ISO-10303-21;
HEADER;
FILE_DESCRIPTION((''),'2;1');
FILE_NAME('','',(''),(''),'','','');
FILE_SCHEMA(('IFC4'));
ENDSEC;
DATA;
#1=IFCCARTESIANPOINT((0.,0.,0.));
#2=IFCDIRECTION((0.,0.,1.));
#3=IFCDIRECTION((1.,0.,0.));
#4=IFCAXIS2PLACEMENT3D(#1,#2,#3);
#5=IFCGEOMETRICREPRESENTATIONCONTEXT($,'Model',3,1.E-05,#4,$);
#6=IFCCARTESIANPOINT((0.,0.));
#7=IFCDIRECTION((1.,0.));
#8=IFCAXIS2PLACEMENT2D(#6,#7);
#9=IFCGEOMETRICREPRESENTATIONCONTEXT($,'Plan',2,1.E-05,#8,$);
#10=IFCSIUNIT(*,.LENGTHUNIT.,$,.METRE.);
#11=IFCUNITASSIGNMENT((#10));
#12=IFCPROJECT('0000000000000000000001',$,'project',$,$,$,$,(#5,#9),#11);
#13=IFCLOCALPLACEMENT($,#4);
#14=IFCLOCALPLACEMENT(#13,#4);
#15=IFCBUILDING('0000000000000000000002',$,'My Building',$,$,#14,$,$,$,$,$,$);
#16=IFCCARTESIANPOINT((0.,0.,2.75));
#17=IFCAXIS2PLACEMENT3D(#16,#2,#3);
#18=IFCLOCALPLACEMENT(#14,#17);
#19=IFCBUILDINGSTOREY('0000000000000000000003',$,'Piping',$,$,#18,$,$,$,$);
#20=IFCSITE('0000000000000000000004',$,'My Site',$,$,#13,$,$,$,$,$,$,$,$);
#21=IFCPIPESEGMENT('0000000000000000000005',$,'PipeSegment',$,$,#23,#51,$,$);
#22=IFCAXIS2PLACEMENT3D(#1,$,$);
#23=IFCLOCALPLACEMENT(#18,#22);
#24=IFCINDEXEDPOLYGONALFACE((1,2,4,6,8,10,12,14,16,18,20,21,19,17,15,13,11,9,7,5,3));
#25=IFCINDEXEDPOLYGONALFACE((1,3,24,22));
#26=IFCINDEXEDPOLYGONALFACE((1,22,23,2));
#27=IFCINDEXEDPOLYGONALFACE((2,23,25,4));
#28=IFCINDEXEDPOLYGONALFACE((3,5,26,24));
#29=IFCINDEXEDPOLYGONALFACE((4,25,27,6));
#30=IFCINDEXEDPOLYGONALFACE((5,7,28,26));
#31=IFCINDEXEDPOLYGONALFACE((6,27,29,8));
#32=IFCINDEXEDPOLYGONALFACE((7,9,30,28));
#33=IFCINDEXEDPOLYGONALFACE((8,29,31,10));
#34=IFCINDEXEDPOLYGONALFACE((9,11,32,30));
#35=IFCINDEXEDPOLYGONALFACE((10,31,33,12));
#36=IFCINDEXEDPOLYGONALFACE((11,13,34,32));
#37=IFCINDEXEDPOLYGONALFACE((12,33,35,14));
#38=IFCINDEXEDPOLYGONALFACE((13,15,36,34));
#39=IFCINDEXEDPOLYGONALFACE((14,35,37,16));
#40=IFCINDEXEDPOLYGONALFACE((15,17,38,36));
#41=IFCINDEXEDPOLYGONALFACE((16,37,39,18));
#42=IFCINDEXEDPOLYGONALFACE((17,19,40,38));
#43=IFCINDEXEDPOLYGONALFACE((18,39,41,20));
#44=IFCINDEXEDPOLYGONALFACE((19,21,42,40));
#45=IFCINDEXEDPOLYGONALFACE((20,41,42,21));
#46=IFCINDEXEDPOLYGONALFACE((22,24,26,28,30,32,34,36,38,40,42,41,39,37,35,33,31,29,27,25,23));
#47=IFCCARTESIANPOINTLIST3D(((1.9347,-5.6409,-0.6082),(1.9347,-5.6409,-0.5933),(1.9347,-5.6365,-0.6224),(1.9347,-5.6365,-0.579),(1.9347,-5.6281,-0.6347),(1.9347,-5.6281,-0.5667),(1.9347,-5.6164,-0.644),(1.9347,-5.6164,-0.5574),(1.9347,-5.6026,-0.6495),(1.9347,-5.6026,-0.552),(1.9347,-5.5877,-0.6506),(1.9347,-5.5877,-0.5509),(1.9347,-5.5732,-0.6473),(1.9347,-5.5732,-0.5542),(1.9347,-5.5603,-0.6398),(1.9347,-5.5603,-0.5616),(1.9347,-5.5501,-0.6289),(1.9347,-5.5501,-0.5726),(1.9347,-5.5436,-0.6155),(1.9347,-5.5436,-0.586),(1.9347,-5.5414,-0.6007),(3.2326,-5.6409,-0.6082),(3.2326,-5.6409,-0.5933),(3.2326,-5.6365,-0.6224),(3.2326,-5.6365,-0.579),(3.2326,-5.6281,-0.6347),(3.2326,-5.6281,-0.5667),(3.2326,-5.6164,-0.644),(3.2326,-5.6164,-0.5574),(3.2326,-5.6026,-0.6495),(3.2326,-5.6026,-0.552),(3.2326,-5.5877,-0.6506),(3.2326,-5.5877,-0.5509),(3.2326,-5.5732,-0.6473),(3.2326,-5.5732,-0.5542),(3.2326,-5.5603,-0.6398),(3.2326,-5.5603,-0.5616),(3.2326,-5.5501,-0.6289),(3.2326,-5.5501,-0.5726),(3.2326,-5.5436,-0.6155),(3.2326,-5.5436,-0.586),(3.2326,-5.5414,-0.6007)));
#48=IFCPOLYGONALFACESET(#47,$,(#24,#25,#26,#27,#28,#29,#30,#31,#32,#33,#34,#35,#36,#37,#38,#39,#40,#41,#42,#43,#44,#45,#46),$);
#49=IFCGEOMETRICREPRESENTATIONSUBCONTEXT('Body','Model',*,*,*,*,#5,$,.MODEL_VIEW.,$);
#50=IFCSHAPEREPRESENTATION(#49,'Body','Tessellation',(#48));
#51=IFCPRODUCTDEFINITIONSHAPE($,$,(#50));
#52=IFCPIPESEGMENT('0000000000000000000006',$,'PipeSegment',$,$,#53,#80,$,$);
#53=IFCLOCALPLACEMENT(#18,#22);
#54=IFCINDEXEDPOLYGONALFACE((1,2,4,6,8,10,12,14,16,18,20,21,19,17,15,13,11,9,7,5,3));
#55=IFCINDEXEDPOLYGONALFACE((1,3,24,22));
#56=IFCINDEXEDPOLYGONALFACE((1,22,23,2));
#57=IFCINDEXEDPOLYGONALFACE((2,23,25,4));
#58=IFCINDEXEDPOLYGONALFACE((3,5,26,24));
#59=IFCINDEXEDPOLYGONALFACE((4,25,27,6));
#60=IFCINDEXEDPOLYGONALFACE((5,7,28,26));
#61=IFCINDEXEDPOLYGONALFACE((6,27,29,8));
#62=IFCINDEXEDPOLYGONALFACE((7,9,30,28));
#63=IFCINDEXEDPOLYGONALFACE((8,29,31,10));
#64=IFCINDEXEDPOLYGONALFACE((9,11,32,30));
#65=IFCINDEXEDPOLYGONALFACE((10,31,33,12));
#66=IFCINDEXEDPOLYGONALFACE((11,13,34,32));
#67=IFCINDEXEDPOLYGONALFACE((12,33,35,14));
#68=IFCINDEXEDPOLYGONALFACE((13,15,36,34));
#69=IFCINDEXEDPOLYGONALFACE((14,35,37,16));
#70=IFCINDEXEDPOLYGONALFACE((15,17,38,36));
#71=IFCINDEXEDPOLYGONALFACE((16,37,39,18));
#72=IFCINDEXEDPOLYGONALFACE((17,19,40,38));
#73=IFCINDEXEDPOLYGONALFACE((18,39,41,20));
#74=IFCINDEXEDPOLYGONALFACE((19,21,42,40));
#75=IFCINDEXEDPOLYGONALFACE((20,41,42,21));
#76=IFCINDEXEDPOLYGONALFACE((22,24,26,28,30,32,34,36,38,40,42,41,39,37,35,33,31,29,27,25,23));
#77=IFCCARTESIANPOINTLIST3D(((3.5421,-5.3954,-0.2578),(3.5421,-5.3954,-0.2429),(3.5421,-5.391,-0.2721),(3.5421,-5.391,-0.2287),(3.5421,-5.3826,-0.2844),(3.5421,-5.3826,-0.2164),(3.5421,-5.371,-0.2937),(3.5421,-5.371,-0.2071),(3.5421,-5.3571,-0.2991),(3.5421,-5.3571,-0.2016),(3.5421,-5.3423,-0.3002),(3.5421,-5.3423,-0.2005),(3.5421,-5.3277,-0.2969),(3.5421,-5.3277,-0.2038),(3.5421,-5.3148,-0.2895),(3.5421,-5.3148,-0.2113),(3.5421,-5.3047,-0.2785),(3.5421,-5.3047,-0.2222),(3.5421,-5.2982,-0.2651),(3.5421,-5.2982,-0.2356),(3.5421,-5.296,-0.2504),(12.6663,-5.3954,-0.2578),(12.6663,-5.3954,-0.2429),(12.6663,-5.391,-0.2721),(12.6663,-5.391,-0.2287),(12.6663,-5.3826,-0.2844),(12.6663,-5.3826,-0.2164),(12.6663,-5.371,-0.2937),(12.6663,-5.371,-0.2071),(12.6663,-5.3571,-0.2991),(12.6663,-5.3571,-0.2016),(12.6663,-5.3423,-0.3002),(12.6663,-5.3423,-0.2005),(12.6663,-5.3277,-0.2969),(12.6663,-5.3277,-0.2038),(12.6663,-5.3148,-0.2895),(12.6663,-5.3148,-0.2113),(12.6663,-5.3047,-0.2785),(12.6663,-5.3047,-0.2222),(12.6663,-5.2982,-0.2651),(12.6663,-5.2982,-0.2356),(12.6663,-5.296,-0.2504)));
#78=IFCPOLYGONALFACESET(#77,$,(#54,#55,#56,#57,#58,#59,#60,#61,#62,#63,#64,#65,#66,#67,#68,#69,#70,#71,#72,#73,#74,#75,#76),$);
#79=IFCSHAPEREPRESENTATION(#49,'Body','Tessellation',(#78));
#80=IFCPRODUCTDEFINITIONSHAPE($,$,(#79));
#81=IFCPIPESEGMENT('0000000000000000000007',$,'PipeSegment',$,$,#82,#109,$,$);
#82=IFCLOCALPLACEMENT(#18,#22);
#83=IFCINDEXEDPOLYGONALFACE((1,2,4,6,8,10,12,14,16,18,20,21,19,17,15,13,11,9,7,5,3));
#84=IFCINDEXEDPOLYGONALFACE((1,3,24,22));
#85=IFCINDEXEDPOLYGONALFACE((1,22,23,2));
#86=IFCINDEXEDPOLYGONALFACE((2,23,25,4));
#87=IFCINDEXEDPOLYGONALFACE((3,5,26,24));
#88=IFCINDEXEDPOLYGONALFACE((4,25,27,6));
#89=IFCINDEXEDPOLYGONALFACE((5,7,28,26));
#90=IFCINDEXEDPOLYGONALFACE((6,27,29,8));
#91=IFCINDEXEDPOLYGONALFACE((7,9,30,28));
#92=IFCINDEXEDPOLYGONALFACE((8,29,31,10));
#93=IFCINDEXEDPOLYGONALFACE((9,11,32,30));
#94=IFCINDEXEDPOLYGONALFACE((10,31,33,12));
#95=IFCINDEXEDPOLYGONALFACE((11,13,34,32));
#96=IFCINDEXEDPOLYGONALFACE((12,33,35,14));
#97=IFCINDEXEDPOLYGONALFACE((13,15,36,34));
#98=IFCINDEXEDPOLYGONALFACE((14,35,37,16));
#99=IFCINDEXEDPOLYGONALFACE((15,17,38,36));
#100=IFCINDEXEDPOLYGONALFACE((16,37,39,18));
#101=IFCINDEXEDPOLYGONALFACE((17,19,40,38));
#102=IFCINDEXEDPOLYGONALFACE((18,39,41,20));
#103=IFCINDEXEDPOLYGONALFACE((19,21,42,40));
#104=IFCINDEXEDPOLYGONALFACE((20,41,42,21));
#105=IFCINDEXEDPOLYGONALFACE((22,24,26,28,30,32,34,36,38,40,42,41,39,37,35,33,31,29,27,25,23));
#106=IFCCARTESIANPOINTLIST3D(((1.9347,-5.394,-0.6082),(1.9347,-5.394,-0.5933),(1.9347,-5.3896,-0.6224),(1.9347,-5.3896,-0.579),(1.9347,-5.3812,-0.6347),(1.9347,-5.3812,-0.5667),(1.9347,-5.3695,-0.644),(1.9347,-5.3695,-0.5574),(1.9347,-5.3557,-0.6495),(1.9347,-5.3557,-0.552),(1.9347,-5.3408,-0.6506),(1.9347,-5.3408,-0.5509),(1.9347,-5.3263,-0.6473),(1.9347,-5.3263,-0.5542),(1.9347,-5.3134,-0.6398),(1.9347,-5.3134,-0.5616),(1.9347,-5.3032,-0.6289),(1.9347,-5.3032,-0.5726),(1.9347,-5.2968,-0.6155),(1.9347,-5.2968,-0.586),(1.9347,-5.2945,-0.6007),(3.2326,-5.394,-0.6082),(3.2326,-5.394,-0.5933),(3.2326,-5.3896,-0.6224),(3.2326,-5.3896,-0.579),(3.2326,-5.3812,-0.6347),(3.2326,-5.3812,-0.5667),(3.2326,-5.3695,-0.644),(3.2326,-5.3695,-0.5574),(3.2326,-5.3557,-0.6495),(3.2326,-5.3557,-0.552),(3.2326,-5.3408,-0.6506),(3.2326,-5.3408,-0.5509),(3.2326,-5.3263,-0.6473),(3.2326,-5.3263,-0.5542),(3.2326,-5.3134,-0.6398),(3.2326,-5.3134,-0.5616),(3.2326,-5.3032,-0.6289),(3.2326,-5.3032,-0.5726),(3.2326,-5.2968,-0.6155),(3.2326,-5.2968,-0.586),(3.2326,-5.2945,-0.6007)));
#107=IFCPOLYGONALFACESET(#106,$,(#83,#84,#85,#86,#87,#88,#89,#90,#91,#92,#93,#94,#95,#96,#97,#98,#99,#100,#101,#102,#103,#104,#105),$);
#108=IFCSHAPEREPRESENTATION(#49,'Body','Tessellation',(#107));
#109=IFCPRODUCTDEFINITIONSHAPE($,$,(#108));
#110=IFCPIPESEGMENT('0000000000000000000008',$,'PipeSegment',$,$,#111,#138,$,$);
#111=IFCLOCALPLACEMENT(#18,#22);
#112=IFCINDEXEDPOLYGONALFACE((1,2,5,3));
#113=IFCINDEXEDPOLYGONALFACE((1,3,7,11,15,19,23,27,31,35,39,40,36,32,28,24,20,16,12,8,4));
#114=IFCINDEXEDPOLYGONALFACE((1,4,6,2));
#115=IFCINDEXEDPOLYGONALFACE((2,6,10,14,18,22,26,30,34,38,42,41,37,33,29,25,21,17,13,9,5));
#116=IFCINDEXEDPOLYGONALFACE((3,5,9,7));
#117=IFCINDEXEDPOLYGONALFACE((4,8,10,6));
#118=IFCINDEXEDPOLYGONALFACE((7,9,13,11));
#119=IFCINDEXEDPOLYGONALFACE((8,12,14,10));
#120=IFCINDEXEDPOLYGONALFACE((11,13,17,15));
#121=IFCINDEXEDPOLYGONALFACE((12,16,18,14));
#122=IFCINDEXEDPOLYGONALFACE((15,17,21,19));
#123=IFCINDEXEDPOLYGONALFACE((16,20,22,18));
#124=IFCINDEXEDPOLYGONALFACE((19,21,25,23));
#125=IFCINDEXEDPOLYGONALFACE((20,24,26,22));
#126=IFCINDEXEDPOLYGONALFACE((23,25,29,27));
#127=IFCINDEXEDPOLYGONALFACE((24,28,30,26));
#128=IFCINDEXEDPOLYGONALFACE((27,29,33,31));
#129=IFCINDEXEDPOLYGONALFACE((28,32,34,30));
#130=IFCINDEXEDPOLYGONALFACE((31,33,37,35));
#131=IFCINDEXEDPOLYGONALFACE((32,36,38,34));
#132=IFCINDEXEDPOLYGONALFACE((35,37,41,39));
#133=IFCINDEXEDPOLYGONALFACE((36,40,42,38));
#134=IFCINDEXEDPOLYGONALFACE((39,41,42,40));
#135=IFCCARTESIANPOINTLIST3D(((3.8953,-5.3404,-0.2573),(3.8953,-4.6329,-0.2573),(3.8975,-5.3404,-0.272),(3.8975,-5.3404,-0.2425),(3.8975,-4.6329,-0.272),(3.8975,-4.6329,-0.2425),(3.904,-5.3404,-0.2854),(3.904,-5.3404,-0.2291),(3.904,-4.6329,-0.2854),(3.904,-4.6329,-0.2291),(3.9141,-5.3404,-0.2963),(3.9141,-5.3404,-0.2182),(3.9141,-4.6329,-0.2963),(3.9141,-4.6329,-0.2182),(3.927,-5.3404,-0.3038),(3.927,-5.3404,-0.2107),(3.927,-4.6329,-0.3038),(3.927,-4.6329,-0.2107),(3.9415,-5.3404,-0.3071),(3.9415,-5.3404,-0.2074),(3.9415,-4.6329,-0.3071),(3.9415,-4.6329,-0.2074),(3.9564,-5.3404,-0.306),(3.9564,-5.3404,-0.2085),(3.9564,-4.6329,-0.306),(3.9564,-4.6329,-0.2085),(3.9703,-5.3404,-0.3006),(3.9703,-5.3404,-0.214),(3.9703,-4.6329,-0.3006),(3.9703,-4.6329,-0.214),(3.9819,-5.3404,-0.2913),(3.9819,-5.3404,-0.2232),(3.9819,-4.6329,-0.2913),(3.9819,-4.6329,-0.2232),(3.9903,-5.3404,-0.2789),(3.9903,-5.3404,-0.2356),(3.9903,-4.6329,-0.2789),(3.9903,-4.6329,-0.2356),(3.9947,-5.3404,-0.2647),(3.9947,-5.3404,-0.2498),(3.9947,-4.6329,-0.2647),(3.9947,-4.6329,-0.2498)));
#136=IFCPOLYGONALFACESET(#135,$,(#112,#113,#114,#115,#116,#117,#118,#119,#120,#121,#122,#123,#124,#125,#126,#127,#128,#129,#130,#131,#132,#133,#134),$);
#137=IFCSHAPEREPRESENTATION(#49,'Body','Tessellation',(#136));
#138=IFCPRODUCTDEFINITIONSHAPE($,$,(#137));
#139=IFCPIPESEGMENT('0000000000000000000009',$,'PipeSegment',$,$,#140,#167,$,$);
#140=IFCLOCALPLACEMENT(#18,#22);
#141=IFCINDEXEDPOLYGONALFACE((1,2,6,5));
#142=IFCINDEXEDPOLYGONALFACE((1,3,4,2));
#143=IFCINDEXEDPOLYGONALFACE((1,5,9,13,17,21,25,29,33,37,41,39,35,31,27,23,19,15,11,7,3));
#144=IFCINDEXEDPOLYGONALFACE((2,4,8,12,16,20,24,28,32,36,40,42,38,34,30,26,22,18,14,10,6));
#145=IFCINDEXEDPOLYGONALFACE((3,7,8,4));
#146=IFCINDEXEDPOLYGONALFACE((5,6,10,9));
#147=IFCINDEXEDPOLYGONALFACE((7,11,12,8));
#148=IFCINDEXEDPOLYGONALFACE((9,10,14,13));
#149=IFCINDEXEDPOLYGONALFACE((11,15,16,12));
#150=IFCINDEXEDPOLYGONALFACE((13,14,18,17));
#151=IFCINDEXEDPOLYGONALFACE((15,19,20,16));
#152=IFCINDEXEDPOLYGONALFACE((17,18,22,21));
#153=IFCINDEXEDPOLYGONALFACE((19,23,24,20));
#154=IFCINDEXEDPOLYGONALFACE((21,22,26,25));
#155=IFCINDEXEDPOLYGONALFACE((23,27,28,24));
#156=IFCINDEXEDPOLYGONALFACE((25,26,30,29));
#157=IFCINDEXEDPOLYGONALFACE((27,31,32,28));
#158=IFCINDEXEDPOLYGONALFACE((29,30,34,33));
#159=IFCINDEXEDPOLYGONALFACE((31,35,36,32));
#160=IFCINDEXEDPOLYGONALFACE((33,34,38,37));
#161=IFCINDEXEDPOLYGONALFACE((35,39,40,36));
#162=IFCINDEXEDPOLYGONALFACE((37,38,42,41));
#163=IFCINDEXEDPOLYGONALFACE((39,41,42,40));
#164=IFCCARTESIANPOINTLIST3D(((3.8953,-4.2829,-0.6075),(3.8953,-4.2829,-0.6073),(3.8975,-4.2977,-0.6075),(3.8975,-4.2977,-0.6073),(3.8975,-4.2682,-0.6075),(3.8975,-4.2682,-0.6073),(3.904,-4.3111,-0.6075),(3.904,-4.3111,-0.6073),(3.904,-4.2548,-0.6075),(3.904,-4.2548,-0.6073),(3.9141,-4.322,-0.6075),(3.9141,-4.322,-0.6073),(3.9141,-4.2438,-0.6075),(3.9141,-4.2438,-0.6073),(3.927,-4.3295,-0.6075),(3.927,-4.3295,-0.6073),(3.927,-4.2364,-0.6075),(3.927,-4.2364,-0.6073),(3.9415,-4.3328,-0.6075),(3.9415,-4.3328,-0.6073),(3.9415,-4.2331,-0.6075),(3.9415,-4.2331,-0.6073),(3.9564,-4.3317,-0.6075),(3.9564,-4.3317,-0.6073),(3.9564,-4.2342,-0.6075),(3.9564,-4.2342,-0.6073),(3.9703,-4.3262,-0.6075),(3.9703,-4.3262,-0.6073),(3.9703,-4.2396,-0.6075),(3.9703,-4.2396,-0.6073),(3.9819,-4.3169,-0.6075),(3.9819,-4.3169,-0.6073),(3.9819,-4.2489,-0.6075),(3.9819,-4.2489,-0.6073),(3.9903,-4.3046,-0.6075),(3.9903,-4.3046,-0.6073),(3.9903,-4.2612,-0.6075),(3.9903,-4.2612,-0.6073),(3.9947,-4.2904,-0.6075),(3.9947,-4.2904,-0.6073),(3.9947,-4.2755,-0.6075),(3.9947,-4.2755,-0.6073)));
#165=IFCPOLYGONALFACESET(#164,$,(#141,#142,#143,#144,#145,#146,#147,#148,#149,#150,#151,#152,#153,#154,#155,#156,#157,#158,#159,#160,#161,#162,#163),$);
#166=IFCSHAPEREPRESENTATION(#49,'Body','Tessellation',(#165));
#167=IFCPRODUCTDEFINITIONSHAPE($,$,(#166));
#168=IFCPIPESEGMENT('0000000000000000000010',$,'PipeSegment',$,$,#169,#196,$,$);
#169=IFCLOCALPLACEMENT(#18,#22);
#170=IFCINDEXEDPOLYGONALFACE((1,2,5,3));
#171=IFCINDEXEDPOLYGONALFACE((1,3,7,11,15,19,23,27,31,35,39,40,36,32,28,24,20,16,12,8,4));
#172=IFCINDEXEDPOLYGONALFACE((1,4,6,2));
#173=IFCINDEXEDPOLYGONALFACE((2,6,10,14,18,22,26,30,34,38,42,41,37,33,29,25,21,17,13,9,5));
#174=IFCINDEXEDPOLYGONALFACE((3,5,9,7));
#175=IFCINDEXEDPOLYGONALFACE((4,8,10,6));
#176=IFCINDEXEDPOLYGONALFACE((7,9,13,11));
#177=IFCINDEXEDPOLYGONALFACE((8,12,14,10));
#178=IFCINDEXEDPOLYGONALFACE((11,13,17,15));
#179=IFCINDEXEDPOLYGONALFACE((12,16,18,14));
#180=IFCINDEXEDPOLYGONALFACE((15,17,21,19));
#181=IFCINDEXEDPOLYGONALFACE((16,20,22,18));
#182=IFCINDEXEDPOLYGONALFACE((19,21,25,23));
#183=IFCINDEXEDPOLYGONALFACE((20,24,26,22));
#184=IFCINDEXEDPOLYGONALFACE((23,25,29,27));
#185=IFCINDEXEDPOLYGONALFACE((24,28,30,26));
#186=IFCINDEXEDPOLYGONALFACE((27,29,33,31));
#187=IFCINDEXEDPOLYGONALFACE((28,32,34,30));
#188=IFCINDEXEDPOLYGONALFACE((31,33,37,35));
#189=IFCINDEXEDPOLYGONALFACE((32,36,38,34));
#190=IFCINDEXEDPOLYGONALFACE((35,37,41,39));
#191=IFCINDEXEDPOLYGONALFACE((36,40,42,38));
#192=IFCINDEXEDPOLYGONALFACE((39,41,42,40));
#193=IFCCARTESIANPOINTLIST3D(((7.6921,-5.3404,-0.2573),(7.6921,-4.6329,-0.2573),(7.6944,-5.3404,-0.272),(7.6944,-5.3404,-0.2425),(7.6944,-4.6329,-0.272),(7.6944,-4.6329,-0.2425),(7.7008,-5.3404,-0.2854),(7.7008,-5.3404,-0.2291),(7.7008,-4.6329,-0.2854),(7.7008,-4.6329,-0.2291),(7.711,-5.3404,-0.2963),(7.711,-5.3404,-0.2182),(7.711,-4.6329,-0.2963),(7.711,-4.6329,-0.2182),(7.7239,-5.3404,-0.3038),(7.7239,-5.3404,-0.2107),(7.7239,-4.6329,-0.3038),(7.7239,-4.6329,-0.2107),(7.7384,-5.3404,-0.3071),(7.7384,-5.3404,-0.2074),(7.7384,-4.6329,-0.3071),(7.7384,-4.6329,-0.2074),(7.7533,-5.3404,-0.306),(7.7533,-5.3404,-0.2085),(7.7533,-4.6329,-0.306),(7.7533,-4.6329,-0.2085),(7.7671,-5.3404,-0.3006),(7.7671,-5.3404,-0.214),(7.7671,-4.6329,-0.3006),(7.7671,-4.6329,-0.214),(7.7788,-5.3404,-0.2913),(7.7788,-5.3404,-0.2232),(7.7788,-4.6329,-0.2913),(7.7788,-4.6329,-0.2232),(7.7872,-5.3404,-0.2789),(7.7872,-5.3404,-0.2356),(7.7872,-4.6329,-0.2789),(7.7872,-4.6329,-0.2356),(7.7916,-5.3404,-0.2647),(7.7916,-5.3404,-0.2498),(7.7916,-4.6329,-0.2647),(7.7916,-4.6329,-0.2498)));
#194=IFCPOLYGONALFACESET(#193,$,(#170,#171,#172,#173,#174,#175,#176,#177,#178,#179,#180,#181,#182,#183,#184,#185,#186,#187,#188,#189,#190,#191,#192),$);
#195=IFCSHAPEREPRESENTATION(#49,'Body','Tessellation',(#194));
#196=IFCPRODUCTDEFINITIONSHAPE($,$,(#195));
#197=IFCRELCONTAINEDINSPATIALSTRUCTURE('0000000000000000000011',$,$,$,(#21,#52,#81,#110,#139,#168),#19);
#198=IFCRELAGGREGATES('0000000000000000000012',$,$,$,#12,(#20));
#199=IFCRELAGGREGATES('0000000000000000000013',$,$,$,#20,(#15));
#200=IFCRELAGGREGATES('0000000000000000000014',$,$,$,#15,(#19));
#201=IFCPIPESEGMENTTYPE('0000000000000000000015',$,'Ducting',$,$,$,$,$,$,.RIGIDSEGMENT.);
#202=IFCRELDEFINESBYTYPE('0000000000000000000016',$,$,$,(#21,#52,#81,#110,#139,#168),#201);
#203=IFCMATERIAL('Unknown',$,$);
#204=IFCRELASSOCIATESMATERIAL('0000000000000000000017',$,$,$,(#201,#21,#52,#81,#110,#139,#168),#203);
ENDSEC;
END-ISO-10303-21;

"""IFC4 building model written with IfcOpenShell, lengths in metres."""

from ifc_helpers import new_model, si_unit, frame, origin_with_axes, origin_2d_with_axis, place, context, subcontext, project, spatial, circle, extrude, material, material_profile, profile_set, profile_usage, type_object, element, save


model = new_model("IFC4")

# Units and contexts
model_context = context("Model", 3, precision=1e-05, world=origin_with_axes())
plan_context = context("Plan", 2, precision=1e-05, world=origin_2d_with_axis())
body_context = subcontext(model_context, "Body", "Model", "MODEL_VIEW")
ifc_project = project(units=[si_unit("LENGTHUNIT", "METRE")], contexts=[model_context, plan_context])

# Site, building, storey
site_placement = place(None, origin_with_axes())
site = spatial("IfcSite", under=ifc_project, at=site_placement, Name="My Site")
building_placement = place(site_placement, origin_with_axes())
building = spatial("IfcBuilding", under=site, at=building_placement, Name="My Building")
storey_placement = place(building_placement, frame((0.0, 0.0, 2.75), z_axis=(0.0, 0.0, 1.0), x_axis=(1.0, 0.0, 0.0)))
storey = spatial("IfcBuildingStorey", under=building, at=storey_placement, Name="Piping")

# Pipe segments
ifc_material = material(Name="Unknown")
ifc_material_profile = material_profile(ifc_material, circle(Radius=0.05))
ifc_profile_set = profile_set([ifc_material_profile])
pipe_segment_type = type_object("IfcPipeSegmentType", Name="Ducting", PredefinedType="RIGIDSEGMENT", material=ifc_profile_set)
ifc_profile_usage_1 = profile_usage(ifc_profile_set, cardinal=4)
pipe_segment_1_placement = place(storey_placement, frame((1.9347, -5.5414, -0.6007), z_axis=(1.0, 0.0, 0.0), x_axis=(0.0, 1.0, 0.0)))
element("IfcPipeSegment", 1, at=pipe_segment_1_placement, inside=storey, type_object=pipe_segment_type, material=ifc_profile_usage_1, Name="PipeSegment", context=body_context, shape_type="SweptSolid", body=[
    extrude(circle(Radius=0.05), frame((-0.05, 0.0, 0.0), z_axis=(0.0, 0.0, 1.0), x_axis=(1.0, 0.0, 0.0)), (0.0, 0.0, 1.0), 1.298),
])
ifc_profile_usage_2 = profile_usage(ifc_profile_set, cardinal=4)
pipe_segment_2_placement = place(storey_placement, frame((3.5421, -5.296, -0.2504), z_axis=(1.0, -0.000001, 0.000001), x_axis=(0.000001, 1.0, 0.0)))
element("IfcPipeSegment", 2, at=pipe_segment_2_placement, inside=storey, type_object=pipe_segment_type, material=ifc_profile_usage_2, Name="PipeSegment", context=body_context, shape_type="SweptSolid", body=[
    extrude(circle(Radius=0.05), frame((-0.05, 0.0, 0.0), z_axis=(0.0, 0.0, 1.0), x_axis=(1.0, 0.0, 0.0)), (0.0, 0.0, 1.0), 9.1242),
])
ifc_profile_usage_3 = profile_usage(ifc_profile_set, cardinal=4)
pipe_segment_3_placement = place(storey_placement, frame((1.9347, -5.2945, -0.6007), z_axis=(1.0, 0.0, 0.0), x_axis=(0.0, 1.0, 0.0)))
element("IfcPipeSegment", 3, at=pipe_segment_3_placement, inside=storey, type_object=pipe_segment_type, material=ifc_profile_usage_3, Name="PipeSegment", context=body_context, shape_type="SweptSolid", body=[
    extrude(circle(Radius=0.05), frame((-0.05, 0.0, 0.0), z_axis=(0.0, 0.0, 1.0), x_axis=(1.0, 0.0, 0.0)), (0.0, 0.0, 1.0), 1.298),
])
ifc_profile_usage_4 = profile_usage(ifc_profile_set, cardinal=4)
pipe_segment_4_placement = place(storey_placement, frame((3.8953, -5.3404, -0.2573), z_axis=(0.0, 1.0, 0.0), x_axis=(-1.0, 0.0, 0.0)))
element("IfcPipeSegment", 4, at=pipe_segment_4_placement, inside=storey, type_object=pipe_segment_type, material=ifc_profile_usage_4, Name="PipeSegment", context=body_context, shape_type="SweptSolid", body=[
    extrude(circle(Radius=0.05), frame((-0.05, 0.0, 0.0), z_axis=(0.0, 0.0, 1.0), x_axis=(1.0, 0.0, 0.0)), (0.0, 0.0, 1.0), 0.7075),
])
ifc_profile_usage_5 = profile_usage(ifc_profile_set, cardinal=4)
pipe_segment_5_placement = place(storey_placement, frame((3.8953, -4.2829, -0.6073), z_axis=(0.0, 0.0, -1.0), x_axis=(-1.0, 0.0, 0.0)))
element("IfcPipeSegment", 5, at=pipe_segment_5_placement, inside=storey, type_object=pipe_segment_type, material=ifc_profile_usage_5, Name="PipeSegment", context=body_context, shape_type="SweptSolid", body=[
    extrude(circle(Radius=0.05), frame((-0.05, 0.0, 0.0), z_axis=(0.0, 0.0, 1.0), x_axis=(1.0, 0.0, 0.0)), (0.0, 0.0, 1.0), 0.0003),
])
ifc_profile_usage_6 = profile_usage(ifc_profile_set, cardinal=4)
pipe_segment_6_placement = place(storey_placement, frame((7.6921, -5.3404, -0.2573), z_axis=(0.0, 1.0, 0.0), x_axis=(-1.0, 0.0, 0.0)))
element("IfcPipeSegment", 6, at=pipe_segment_6_placement, inside=storey, type_object=pipe_segment_type, material=ifc_profile_usage_6, Name="PipeSegment", context=body_context, shape_type="SweptSolid", body=[
    extrude(circle(Radius=0.05), frame((-0.05, 0.0, 0.0), z_axis=(0.0, 0.0, 1.0), x_axis=(1.0, 0.0, 0.0)), (0.0, 0.0, 1.0), 0.7075),
])

save(model, "model.ifc")
